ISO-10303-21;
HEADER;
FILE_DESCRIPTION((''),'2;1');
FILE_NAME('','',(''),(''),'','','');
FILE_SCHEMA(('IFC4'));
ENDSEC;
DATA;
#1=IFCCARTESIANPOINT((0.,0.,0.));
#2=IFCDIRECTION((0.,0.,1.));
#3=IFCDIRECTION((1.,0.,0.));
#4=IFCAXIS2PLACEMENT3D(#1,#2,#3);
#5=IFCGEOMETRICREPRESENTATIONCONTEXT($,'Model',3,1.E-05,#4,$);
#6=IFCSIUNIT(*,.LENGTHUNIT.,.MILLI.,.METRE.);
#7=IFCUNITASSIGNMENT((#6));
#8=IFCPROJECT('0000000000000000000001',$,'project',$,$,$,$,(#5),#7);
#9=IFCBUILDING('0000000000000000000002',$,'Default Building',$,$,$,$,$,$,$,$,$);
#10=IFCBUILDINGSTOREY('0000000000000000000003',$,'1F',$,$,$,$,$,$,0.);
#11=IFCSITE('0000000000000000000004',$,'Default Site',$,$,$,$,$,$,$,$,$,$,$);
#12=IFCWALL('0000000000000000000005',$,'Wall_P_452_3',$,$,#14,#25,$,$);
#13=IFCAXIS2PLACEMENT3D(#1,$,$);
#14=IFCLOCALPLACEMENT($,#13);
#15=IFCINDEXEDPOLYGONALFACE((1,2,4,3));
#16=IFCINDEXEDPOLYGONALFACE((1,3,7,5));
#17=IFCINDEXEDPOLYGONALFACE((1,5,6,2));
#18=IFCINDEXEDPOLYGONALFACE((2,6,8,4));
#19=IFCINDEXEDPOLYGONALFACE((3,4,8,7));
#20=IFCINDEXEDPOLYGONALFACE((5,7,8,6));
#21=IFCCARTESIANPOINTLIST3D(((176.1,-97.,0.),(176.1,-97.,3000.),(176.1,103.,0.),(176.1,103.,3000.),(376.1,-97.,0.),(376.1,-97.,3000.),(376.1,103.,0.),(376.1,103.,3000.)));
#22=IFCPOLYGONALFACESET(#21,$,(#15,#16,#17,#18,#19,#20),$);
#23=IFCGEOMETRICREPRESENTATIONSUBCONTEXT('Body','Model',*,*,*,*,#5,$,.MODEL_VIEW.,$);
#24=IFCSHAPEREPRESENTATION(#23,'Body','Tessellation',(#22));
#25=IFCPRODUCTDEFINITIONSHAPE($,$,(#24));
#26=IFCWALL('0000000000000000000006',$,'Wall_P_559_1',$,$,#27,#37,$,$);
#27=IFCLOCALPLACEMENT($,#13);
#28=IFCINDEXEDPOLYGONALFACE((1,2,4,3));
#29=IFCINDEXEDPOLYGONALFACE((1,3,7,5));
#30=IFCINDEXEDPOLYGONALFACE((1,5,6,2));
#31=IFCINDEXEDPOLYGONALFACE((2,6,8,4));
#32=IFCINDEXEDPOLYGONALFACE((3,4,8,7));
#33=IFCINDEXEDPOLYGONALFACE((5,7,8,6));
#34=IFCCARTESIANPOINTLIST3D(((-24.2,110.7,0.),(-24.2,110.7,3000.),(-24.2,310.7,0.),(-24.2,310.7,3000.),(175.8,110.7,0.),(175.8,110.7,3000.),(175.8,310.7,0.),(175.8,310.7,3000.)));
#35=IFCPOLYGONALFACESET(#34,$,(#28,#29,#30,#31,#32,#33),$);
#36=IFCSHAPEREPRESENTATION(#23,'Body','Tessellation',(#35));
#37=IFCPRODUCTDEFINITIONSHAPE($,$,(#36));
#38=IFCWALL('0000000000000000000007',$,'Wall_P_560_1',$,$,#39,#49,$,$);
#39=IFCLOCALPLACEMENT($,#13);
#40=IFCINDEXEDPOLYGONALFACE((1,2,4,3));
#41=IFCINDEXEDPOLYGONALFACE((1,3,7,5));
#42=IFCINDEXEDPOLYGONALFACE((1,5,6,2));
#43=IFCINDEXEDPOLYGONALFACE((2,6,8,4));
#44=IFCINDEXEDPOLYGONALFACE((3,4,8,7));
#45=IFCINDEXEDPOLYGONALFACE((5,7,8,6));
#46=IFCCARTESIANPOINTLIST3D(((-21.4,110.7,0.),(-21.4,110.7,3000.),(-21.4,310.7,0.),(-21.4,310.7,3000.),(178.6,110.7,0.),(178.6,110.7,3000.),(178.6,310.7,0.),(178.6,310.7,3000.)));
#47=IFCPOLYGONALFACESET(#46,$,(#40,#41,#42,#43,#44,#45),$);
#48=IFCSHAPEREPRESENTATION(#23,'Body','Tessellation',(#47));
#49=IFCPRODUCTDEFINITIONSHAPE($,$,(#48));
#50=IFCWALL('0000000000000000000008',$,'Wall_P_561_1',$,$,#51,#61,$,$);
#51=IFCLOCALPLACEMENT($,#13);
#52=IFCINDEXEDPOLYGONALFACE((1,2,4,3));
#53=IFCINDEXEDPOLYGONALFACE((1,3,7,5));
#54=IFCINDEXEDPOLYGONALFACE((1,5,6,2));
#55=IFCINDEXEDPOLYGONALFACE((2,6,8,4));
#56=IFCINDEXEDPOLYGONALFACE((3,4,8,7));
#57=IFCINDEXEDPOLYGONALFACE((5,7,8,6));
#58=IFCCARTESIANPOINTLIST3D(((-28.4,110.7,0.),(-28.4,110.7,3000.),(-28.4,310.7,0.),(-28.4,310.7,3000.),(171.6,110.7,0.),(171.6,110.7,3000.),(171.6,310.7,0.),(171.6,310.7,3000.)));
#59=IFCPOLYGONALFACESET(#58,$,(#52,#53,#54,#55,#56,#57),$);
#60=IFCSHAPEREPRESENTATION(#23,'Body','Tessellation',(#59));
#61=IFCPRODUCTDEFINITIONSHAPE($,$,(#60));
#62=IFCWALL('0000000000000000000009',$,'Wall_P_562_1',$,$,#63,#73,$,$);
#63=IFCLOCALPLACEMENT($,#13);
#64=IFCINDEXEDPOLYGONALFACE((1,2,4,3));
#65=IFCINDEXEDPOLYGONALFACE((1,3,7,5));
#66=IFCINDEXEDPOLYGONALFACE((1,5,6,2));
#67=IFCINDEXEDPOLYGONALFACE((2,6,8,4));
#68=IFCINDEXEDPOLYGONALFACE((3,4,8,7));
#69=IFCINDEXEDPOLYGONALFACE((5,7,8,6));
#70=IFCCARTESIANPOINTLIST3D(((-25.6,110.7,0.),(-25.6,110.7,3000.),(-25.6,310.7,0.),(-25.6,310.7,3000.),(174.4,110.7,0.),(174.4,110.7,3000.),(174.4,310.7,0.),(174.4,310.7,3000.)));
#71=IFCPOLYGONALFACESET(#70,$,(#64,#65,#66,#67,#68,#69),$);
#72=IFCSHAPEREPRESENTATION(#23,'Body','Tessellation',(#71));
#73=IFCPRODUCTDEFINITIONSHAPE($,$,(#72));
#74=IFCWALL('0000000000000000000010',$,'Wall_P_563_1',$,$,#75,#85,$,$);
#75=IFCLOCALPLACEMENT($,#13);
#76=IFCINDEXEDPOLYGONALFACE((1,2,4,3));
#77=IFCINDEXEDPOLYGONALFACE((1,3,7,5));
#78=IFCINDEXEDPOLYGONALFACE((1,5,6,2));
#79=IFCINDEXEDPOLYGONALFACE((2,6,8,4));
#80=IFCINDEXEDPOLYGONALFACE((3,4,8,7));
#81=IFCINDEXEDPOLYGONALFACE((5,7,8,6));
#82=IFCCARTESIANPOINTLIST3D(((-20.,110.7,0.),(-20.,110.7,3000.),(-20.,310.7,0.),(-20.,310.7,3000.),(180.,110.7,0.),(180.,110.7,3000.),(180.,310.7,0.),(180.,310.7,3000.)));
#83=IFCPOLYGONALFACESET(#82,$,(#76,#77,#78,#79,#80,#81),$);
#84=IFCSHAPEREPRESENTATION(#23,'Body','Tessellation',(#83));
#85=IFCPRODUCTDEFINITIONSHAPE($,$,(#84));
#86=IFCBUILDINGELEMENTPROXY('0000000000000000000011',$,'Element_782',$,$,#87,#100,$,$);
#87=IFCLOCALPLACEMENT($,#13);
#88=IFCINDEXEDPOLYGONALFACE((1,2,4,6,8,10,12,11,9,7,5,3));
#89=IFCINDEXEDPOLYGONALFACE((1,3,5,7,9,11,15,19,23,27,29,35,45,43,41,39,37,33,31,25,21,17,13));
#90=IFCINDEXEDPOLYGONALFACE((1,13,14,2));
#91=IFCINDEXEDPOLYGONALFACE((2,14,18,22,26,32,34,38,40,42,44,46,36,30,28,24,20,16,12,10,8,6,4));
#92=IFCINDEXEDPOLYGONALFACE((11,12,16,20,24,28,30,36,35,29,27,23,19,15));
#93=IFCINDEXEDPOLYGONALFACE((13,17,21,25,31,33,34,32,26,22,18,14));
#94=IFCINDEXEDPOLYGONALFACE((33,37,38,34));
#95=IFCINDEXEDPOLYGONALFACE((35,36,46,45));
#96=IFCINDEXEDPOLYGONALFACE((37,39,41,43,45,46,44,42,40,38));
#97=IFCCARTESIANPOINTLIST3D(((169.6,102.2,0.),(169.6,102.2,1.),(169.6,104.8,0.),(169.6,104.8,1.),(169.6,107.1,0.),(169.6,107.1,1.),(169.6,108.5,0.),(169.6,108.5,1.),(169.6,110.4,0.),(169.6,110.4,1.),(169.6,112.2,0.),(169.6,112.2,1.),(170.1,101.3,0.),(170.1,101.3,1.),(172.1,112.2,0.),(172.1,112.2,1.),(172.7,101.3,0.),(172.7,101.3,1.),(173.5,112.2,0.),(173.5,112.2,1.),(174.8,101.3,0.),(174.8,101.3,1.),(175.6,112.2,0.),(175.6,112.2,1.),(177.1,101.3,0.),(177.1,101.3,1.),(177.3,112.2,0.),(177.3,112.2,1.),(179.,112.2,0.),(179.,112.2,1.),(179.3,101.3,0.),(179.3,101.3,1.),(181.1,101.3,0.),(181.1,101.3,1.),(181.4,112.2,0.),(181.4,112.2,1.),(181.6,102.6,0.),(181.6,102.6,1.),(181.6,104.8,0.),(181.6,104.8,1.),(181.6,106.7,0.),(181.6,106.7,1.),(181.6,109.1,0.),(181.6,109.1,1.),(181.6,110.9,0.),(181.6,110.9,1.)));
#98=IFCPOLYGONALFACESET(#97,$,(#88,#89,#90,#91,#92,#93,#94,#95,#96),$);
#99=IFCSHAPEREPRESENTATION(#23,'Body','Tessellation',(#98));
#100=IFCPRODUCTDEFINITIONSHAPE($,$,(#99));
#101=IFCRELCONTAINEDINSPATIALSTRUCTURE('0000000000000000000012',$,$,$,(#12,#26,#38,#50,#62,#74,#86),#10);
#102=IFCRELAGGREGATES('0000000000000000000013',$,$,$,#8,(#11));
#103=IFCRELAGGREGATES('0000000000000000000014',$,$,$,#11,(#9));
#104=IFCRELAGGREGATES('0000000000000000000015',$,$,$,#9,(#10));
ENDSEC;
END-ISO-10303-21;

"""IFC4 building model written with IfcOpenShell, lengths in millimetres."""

from ifc_helpers import new_model, si_unit, frame, origin, origin_with_axes, place, context, subcontext, project, spatial, polyline, indexed_curve, outline, extrude, element, save


model = new_model("IFC4")

# Units and contexts
model_context = context("Model", 3, precision=1e-05, world=origin_with_axes())
body_context = subcontext(model_context, "Body", "Model", "MODEL_VIEW")
ifc_project = project(units=[si_unit("LENGTHUNIT", "METRE", prefix="MILLI")], contexts=[model_context])

# Site, building, storey
site = spatial("IfcSite", under=ifc_project, Name="Default Site")
building = spatial("IfcBuilding", under=site, Name="Default Building")
storey = spatial("IfcBuildingStorey", under=building, Name="1F", Elevation=0.0)

# Walls
wall_1_placement = place(None, frame((176.1, 103.0, 0.0), z_axis=(0.0, 0.0, 1.0), x_axis=(0.0, -1.0, 0.0)))
element("IfcWall", 1, at=wall_1_placement, inside=storey, Name="Wall_P_452_3", context=body_context, shape_type="SweptSolid", body=[
    extrude(outline(indexed_curve([(0.0, 0.0), (0.0, 200.0), (200.0, 200.0), (200.0, 0.0), (0.0, 0.0)], self_intersect=False)), origin_with_axes(), (0.0, 0.0, 1.0), 3000.0),
])
for number, where, z_axis, x_axis, name in (
    (2, (175.8, 110.7, 0.0), (0.0, 0.0, 1.0), (0.0, 1.0, 0.0), "Wall_P_559_1"),
    (3, (178.6, 110.7, 0.0), (0.0, 0.0, 1.0), (0.0, 1.0, 0.0), "Wall_P_560_1"),
    (4, (171.6, 110.7, 0.0), (0.0, 0.0, 1.0), (0.0, 1.0, 0.0), "Wall_P_561_1"),
    (5, (174.4, 110.7, 0.0), (0.0, 0.0, 1.0), (0.0, 1.0, 0.0), "Wall_P_562_1"),
    (6, (180.0, 110.7, 0.0), (0.0, 0.0, 1.0), (0.0, 1.0, 0.0), "Wall_P_563_1"),
):
    element("IfcWall", number, at=place(None, frame(where, z_axis=z_axis, x_axis=x_axis)), inside=storey, Name=name, context=body_context, shape_type="SweptSolid", body=[
        extrude(outline(indexed_curve([(0.0, 0.0), (0.0, 200.0), (200.0, 200.0), (200.0, 0.0), (0.0, 0.0)], self_intersect=False)), origin_with_axes(), (0.0, 0.0, 1.0), 3000.0),
    ])

# Building element proxy
proxy_1_placement = place(None, frame((175.6, 107.0, 0.0), z_axis=(0.0, 0.0, 1.0), x_axis=(1.0, 0.0, 0.0)))
element("IfcBuildingElementProxy", 7, at=proxy_1_placement, inside=storey, Name="Element_782", context=body_context, shape_type="SweptSolid", body=[
    extrude(outline(polyline([(-6.0, 5.2), (-3.5, 5.2), (-2.2, 5.2), (-0.1, 5.2), (1.6, 5.2), (3.4, 5.2), (5.8, 5.2), (6.0, 3.9), (6.0, 2.1), (6.0, -0.2), (6.0, -2.2), (6.0, -4.4), (5.5, -5.7), (3.7, -5.7), (1.4, -5.7), (-0.8, -5.7), (-3.0, -5.7), (-5.5, -5.7), (-6.0, -4.8), (-6.0, -2.1), (-6.0, 0.2), (-6.0, 1.6), (-6.0, 3.5), (-6.0, 5.2)])), origin(), (0.0, 0.0, 1.0), 1.0),
])

save(model, "model.ifc")
